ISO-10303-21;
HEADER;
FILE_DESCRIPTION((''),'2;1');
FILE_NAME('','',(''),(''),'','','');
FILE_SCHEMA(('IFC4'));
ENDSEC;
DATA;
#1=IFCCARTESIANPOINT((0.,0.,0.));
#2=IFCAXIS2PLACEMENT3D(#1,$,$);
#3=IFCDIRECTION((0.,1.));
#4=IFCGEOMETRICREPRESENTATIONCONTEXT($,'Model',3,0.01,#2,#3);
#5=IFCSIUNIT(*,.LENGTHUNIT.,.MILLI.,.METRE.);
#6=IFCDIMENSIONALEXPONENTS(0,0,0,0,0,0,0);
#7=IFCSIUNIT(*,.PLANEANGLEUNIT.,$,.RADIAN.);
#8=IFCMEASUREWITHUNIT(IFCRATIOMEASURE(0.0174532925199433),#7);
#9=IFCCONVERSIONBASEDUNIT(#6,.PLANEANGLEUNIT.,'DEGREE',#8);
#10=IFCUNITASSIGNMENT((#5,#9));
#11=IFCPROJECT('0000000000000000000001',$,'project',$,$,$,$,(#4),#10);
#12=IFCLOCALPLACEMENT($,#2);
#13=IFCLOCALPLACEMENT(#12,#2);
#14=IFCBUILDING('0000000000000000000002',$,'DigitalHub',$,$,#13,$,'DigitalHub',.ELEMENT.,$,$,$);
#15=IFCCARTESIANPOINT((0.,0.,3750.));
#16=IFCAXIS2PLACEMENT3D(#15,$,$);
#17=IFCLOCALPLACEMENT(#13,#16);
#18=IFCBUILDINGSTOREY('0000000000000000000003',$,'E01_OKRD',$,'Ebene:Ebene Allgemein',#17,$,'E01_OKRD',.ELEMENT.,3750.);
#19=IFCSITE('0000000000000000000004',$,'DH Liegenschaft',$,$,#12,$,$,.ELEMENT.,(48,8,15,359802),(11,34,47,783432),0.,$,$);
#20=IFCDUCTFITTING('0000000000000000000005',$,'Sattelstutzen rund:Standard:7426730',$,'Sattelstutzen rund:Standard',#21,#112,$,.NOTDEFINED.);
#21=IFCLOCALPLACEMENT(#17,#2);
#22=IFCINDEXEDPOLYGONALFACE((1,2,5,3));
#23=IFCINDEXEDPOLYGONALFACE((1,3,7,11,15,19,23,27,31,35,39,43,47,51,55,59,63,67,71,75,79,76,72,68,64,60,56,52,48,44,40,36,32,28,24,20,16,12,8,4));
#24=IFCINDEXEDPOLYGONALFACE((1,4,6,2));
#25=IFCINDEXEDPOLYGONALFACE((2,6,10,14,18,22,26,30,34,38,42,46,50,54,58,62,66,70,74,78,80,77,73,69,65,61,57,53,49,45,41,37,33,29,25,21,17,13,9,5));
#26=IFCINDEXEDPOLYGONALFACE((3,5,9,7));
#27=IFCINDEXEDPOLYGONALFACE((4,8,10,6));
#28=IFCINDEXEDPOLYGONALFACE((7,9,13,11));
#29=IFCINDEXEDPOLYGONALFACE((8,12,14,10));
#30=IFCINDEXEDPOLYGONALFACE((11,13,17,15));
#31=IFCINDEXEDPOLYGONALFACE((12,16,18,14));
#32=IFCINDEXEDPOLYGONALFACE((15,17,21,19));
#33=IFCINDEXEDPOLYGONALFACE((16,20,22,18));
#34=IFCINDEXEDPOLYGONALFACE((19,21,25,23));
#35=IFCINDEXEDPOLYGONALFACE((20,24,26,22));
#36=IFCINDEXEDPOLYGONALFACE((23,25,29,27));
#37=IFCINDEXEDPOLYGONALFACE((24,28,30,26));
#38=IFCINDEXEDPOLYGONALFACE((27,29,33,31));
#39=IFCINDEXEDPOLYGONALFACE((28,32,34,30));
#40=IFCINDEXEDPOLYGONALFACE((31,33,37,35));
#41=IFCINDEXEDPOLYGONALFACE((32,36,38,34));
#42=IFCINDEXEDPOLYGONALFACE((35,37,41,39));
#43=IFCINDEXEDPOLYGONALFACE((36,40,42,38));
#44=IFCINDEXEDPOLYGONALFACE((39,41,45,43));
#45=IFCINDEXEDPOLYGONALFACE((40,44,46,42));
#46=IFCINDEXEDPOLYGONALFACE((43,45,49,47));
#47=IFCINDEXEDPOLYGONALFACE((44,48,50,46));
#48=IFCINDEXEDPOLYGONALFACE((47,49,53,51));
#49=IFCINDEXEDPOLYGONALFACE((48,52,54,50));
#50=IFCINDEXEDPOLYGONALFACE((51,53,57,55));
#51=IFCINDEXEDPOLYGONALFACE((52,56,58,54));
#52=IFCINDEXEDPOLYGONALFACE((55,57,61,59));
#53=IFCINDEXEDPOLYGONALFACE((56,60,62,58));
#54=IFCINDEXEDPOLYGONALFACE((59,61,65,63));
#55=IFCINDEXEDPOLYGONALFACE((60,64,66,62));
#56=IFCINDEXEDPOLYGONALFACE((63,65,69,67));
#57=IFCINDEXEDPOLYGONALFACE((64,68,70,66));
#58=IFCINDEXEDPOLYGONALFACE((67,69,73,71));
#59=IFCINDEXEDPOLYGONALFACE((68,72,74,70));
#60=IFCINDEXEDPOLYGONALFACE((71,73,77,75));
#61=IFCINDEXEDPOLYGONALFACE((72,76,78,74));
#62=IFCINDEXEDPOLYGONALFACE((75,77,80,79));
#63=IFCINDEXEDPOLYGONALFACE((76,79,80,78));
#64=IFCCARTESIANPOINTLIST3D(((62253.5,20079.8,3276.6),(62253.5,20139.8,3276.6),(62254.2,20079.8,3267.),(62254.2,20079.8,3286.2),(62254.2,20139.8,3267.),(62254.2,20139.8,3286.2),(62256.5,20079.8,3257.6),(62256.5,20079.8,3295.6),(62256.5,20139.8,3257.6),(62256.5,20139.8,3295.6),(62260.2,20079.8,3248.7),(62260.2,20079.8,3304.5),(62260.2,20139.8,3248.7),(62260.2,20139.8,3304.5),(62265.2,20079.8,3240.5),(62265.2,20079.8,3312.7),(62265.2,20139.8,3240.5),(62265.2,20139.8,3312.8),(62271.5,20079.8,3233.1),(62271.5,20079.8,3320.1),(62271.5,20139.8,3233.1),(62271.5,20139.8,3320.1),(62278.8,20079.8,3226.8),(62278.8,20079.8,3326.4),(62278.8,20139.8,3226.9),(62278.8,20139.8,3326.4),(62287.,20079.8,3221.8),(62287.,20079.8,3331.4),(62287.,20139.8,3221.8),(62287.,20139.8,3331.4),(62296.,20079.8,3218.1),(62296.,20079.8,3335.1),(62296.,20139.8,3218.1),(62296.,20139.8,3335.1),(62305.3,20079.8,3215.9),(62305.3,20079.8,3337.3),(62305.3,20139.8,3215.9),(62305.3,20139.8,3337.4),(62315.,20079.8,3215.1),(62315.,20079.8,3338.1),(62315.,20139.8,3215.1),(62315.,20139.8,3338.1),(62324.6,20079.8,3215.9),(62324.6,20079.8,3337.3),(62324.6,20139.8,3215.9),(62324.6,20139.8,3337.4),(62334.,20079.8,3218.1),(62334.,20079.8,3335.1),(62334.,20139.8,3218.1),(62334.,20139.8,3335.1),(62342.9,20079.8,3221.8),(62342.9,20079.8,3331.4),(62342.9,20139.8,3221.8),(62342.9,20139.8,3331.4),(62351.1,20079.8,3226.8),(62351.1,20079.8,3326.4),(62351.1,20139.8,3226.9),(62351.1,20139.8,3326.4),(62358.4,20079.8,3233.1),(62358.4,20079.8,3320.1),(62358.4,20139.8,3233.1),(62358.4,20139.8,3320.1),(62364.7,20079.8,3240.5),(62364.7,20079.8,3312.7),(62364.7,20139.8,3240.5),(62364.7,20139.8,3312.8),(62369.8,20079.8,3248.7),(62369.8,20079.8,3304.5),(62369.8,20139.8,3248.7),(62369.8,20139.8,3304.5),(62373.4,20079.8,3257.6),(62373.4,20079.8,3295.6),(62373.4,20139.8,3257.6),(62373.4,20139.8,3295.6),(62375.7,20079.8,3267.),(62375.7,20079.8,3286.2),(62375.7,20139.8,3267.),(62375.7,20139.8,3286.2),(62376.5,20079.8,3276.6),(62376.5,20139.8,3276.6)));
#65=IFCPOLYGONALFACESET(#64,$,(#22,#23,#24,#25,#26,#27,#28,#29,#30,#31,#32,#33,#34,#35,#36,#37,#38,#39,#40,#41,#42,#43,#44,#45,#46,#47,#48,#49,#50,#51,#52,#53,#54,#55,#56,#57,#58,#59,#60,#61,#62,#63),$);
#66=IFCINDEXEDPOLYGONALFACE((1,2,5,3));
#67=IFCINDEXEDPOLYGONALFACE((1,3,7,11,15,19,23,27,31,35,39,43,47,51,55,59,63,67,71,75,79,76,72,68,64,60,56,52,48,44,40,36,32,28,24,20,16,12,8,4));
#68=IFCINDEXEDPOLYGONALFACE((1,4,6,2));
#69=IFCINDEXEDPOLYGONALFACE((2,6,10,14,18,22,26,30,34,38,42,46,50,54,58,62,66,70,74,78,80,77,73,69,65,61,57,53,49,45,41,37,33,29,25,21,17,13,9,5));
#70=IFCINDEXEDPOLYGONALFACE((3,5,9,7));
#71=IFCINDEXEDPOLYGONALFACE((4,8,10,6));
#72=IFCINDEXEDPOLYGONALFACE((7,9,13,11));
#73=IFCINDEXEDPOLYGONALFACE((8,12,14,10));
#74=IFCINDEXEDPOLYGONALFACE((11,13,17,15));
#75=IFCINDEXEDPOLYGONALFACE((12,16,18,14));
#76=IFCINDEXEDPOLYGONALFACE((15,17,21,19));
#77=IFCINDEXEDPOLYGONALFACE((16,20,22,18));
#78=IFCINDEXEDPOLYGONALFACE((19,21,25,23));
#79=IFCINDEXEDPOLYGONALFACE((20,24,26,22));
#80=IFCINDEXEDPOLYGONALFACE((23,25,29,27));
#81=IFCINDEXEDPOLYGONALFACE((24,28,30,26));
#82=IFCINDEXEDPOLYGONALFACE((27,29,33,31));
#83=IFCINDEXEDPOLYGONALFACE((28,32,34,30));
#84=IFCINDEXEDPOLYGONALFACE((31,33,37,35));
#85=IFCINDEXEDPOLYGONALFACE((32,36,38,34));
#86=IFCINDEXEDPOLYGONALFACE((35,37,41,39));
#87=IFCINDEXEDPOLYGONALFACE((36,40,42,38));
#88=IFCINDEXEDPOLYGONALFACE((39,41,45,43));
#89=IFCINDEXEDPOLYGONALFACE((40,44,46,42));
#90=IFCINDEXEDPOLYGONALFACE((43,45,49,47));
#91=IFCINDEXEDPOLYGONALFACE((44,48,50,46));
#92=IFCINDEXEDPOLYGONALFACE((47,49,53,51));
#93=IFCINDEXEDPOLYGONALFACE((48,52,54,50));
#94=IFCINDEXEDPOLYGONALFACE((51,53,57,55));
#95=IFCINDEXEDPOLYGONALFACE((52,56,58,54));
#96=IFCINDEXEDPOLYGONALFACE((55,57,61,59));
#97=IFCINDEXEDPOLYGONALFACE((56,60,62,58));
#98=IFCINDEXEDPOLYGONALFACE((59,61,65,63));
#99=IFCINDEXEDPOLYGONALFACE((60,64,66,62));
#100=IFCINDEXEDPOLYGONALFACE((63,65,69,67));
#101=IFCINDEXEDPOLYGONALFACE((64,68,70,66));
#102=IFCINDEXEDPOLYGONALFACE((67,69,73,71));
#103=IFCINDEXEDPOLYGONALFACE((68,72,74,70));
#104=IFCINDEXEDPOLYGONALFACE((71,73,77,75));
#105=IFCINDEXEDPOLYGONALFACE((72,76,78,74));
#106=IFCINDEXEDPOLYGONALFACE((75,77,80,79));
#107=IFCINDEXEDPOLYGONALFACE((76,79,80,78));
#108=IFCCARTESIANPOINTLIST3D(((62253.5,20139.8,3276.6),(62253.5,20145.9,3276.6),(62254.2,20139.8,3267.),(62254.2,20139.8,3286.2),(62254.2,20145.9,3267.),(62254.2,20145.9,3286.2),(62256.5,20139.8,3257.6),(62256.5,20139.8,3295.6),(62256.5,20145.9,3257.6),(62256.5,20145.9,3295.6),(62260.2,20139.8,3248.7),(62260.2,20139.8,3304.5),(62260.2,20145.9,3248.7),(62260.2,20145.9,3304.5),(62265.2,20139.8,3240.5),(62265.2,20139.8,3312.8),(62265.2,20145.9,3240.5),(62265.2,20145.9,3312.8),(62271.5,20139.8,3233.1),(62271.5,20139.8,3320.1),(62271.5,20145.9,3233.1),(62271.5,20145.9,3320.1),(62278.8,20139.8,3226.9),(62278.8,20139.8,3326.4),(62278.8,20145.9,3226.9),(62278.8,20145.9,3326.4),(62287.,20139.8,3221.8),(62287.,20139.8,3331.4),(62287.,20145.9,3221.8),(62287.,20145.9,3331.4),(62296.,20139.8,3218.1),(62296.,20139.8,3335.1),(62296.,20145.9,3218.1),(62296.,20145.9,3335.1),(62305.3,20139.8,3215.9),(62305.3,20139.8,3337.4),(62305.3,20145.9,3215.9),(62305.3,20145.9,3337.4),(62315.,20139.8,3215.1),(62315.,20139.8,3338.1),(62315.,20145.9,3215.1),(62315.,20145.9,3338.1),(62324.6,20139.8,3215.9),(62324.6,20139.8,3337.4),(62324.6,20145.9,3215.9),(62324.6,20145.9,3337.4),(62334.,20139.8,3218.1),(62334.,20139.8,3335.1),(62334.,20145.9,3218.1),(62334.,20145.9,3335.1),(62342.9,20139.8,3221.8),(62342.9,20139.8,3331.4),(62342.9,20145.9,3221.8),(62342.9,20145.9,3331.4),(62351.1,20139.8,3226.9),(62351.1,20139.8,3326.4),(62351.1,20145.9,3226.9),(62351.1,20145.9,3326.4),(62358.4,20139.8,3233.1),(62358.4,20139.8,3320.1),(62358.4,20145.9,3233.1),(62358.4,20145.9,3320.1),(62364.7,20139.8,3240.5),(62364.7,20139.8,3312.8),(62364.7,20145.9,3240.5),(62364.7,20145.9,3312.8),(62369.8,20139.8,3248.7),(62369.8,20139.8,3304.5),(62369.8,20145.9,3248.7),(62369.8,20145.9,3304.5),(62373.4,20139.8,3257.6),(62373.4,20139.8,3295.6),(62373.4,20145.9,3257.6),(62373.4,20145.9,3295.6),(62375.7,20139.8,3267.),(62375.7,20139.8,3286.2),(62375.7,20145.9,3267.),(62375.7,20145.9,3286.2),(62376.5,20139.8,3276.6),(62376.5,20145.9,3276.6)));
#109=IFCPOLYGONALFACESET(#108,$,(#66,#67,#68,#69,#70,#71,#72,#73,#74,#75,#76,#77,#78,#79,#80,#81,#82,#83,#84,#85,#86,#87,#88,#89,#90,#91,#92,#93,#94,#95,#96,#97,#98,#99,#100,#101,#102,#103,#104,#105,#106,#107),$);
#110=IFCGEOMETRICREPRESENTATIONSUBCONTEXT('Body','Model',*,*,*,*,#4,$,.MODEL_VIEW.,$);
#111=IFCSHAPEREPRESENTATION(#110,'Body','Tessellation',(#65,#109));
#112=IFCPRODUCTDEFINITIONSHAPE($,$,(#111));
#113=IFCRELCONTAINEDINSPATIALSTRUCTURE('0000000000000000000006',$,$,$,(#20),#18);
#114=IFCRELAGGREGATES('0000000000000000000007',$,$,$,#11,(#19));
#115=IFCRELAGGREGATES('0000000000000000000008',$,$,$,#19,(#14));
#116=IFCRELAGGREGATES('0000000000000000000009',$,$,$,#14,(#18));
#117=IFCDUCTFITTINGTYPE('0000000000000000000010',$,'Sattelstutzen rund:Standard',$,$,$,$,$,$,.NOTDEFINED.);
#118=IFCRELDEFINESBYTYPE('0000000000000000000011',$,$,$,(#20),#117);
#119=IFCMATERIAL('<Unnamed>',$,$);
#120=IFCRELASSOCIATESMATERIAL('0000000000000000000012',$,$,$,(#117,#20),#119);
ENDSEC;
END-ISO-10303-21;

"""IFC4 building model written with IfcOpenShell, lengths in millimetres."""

from ifc_helpers import new_model, entity, si_unit, converted_unit, direction, frame, origin, place, context, subcontext, project, spatial, indexed_curve, outline, extrude, source, transform, mapped, material, type_object, type_shapes, element, save


model = new_model("IFC4")

# Units and contexts
model_context = context("Model", 3, precision=0.01, world=origin(), true_north=direction((0.0, 1.0)))
body_context = subcontext(model_context, "Body", "Model", "MODEL_VIEW")
ifc_project = project(units=[si_unit("LENGTHUNIT", "METRE", prefix="MILLI"), converted_unit("PLANEANGLEUNIT", "DEGREE", entity("IfcRatioMeasure", 0.0174532925199433), si_unit("PLANEANGLEUNIT", "RADIAN"), dimensions=[0, 0, 0, 0, 0, 0, 0])], contexts=[model_context])

# Site, building, storey
site_placement = place(None, origin())
site = spatial("IfcSite", under=ifc_project, at=site_placement, Name="DH Liegenschaft", CompositionType="ELEMENT", RefLatitude=(48, 8, 15, 359802), RefLongitude=(11, 34, 47, 783432), RefElevation=0.0)
building_placement = place(site_placement, origin())
building = spatial("IfcBuilding", under=site, at=building_placement, Name="DigitalHub", LongName="DigitalHub", CompositionType="ELEMENT")
storey_placement = place(building_placement, frame((0.0, 0.0, 3750.0)))
storey = spatial("IfcBuildingStorey", under=building, at=storey_placement, Name="E01_OKRD", ObjectType="Ebene:Ebene Allgemein", LongName="E01_OKRD", CompositionType="ELEMENT", Elevation=3750.0)

# Shared definitions
ifc_material_1 = material(Name="<Unnamed>")

# Duct fitting
duct_fitting_type_1 = type_object("IfcDuctFittingType", Name="Sattelstutzen rund:Standard", PredefinedType="NOTDEFINED", material=ifc_material_1)
shared_shape_1 = source(origin(), body_context, "Body", "SweptSolid", [
    extrude(outline(indexed_curve([(0.0, 61.5), (-9.6, 60.7), (-19.0, 58.5), (-27.9, 54.8), (-36.1, 49.8), (-43.5, 43.5), (-49.8, 36.1), (-54.8, 27.9), (-58.5, 19.0), (-60.7, 9.6), (-61.5, 0.0), (-60.7, -9.6), (-58.5, -19.0), (-54.8, -27.9), (-49.8, -36.1), (-43.5, -43.5), (-36.1, -49.8), (-27.9, -54.8), (-19.0, -58.5), (-9.6, -60.7), (0.0, -61.5), (9.6, -60.7), (19.0, -58.5), (27.9, -54.8), (36.1, -49.8), (43.5, -43.5), (49.8, -36.1), (54.8, -27.9), (58.5, -19.0), (60.7, -9.6), (61.5, 0.0), (60.7, 9.6), (58.5, 19.0), (54.8, 27.9), (49.8, 36.1), (43.5, 43.5), (36.1, 49.8), (27.9, 54.8), (19.0, 58.5), (9.6, 60.7), (0.0, 61.5)], self_intersect=False)), frame((0.0, 0.0, 0.0), z_axis=(1.0, 0.0, 0.0), x_axis=(0.0, 1.0, 0.0)), (0.0, 0.0, 1.0), 60.0),
    extrude(outline(indexed_curve([(0.0, 61.5), (-9.6, 60.7), (-19.0, 58.5), (-27.9, 54.8), (-36.1, 49.8), (-43.5, 43.5), (-49.8, 36.1), (-54.8, 27.9), (-58.5, 19.0), (-60.7, 9.6), (-61.5, 0.0), (-60.7, -9.6), (-58.5, -19.0), (-54.8, -27.9), (-49.8, -36.1), (-43.5, -43.5), (-36.1, -49.8), (-27.9, -54.8), (-19.0, -58.5), (-9.6, -60.7), (0.0, -61.5), (9.6, -60.7), (19.0, -58.5), (27.9, -54.8), (36.1, -49.8), (43.5, -43.5), (49.8, -36.1), (54.8, -27.9), (58.5, -19.0), (60.7, -9.6), (61.5, 0.0), (60.7, 9.6), (58.5, 19.0), (54.8, 27.9), (49.8, 36.1), (43.5, 43.5), (36.1, 49.8), (27.9, 54.8), (19.0, 58.5), (9.6, 60.7), (0.0, 61.5)], self_intersect=False)), frame((-6.1, 0.0, 0.0), z_axis=(1.0, 0.0, 0.0), x_axis=(0.0, 1.0, 0.0)), (0.0, 0.0, 1.0), 6.1),
])
type_shapes(duct_fitting_type_1, [shared_shape_1])
duct_fitting_1_placement = place(storey_placement, frame((62315.0, 20139.8, 3276.6), z_axis=(0.0, 0.000188, -1.0), x_axis=(0.0, -1.0, -0.000188)))
element("IfcDuctFitting", 1, at=duct_fitting_1_placement, inside=storey, type_object=duct_fitting_type_1, material=ifc_material_1, Name="Sattelstutzen rund:Standard:7426730", ObjectType="Sattelstutzen rund:Standard", PredefinedType="NOTDEFINED", context=body_context, shape_type="MappedRepresentation", body=[
    mapped(shared_shape_1, transform((0.0, 0.0, 0.0), scale=1.0)),
])

save(model, "model.ifc")
